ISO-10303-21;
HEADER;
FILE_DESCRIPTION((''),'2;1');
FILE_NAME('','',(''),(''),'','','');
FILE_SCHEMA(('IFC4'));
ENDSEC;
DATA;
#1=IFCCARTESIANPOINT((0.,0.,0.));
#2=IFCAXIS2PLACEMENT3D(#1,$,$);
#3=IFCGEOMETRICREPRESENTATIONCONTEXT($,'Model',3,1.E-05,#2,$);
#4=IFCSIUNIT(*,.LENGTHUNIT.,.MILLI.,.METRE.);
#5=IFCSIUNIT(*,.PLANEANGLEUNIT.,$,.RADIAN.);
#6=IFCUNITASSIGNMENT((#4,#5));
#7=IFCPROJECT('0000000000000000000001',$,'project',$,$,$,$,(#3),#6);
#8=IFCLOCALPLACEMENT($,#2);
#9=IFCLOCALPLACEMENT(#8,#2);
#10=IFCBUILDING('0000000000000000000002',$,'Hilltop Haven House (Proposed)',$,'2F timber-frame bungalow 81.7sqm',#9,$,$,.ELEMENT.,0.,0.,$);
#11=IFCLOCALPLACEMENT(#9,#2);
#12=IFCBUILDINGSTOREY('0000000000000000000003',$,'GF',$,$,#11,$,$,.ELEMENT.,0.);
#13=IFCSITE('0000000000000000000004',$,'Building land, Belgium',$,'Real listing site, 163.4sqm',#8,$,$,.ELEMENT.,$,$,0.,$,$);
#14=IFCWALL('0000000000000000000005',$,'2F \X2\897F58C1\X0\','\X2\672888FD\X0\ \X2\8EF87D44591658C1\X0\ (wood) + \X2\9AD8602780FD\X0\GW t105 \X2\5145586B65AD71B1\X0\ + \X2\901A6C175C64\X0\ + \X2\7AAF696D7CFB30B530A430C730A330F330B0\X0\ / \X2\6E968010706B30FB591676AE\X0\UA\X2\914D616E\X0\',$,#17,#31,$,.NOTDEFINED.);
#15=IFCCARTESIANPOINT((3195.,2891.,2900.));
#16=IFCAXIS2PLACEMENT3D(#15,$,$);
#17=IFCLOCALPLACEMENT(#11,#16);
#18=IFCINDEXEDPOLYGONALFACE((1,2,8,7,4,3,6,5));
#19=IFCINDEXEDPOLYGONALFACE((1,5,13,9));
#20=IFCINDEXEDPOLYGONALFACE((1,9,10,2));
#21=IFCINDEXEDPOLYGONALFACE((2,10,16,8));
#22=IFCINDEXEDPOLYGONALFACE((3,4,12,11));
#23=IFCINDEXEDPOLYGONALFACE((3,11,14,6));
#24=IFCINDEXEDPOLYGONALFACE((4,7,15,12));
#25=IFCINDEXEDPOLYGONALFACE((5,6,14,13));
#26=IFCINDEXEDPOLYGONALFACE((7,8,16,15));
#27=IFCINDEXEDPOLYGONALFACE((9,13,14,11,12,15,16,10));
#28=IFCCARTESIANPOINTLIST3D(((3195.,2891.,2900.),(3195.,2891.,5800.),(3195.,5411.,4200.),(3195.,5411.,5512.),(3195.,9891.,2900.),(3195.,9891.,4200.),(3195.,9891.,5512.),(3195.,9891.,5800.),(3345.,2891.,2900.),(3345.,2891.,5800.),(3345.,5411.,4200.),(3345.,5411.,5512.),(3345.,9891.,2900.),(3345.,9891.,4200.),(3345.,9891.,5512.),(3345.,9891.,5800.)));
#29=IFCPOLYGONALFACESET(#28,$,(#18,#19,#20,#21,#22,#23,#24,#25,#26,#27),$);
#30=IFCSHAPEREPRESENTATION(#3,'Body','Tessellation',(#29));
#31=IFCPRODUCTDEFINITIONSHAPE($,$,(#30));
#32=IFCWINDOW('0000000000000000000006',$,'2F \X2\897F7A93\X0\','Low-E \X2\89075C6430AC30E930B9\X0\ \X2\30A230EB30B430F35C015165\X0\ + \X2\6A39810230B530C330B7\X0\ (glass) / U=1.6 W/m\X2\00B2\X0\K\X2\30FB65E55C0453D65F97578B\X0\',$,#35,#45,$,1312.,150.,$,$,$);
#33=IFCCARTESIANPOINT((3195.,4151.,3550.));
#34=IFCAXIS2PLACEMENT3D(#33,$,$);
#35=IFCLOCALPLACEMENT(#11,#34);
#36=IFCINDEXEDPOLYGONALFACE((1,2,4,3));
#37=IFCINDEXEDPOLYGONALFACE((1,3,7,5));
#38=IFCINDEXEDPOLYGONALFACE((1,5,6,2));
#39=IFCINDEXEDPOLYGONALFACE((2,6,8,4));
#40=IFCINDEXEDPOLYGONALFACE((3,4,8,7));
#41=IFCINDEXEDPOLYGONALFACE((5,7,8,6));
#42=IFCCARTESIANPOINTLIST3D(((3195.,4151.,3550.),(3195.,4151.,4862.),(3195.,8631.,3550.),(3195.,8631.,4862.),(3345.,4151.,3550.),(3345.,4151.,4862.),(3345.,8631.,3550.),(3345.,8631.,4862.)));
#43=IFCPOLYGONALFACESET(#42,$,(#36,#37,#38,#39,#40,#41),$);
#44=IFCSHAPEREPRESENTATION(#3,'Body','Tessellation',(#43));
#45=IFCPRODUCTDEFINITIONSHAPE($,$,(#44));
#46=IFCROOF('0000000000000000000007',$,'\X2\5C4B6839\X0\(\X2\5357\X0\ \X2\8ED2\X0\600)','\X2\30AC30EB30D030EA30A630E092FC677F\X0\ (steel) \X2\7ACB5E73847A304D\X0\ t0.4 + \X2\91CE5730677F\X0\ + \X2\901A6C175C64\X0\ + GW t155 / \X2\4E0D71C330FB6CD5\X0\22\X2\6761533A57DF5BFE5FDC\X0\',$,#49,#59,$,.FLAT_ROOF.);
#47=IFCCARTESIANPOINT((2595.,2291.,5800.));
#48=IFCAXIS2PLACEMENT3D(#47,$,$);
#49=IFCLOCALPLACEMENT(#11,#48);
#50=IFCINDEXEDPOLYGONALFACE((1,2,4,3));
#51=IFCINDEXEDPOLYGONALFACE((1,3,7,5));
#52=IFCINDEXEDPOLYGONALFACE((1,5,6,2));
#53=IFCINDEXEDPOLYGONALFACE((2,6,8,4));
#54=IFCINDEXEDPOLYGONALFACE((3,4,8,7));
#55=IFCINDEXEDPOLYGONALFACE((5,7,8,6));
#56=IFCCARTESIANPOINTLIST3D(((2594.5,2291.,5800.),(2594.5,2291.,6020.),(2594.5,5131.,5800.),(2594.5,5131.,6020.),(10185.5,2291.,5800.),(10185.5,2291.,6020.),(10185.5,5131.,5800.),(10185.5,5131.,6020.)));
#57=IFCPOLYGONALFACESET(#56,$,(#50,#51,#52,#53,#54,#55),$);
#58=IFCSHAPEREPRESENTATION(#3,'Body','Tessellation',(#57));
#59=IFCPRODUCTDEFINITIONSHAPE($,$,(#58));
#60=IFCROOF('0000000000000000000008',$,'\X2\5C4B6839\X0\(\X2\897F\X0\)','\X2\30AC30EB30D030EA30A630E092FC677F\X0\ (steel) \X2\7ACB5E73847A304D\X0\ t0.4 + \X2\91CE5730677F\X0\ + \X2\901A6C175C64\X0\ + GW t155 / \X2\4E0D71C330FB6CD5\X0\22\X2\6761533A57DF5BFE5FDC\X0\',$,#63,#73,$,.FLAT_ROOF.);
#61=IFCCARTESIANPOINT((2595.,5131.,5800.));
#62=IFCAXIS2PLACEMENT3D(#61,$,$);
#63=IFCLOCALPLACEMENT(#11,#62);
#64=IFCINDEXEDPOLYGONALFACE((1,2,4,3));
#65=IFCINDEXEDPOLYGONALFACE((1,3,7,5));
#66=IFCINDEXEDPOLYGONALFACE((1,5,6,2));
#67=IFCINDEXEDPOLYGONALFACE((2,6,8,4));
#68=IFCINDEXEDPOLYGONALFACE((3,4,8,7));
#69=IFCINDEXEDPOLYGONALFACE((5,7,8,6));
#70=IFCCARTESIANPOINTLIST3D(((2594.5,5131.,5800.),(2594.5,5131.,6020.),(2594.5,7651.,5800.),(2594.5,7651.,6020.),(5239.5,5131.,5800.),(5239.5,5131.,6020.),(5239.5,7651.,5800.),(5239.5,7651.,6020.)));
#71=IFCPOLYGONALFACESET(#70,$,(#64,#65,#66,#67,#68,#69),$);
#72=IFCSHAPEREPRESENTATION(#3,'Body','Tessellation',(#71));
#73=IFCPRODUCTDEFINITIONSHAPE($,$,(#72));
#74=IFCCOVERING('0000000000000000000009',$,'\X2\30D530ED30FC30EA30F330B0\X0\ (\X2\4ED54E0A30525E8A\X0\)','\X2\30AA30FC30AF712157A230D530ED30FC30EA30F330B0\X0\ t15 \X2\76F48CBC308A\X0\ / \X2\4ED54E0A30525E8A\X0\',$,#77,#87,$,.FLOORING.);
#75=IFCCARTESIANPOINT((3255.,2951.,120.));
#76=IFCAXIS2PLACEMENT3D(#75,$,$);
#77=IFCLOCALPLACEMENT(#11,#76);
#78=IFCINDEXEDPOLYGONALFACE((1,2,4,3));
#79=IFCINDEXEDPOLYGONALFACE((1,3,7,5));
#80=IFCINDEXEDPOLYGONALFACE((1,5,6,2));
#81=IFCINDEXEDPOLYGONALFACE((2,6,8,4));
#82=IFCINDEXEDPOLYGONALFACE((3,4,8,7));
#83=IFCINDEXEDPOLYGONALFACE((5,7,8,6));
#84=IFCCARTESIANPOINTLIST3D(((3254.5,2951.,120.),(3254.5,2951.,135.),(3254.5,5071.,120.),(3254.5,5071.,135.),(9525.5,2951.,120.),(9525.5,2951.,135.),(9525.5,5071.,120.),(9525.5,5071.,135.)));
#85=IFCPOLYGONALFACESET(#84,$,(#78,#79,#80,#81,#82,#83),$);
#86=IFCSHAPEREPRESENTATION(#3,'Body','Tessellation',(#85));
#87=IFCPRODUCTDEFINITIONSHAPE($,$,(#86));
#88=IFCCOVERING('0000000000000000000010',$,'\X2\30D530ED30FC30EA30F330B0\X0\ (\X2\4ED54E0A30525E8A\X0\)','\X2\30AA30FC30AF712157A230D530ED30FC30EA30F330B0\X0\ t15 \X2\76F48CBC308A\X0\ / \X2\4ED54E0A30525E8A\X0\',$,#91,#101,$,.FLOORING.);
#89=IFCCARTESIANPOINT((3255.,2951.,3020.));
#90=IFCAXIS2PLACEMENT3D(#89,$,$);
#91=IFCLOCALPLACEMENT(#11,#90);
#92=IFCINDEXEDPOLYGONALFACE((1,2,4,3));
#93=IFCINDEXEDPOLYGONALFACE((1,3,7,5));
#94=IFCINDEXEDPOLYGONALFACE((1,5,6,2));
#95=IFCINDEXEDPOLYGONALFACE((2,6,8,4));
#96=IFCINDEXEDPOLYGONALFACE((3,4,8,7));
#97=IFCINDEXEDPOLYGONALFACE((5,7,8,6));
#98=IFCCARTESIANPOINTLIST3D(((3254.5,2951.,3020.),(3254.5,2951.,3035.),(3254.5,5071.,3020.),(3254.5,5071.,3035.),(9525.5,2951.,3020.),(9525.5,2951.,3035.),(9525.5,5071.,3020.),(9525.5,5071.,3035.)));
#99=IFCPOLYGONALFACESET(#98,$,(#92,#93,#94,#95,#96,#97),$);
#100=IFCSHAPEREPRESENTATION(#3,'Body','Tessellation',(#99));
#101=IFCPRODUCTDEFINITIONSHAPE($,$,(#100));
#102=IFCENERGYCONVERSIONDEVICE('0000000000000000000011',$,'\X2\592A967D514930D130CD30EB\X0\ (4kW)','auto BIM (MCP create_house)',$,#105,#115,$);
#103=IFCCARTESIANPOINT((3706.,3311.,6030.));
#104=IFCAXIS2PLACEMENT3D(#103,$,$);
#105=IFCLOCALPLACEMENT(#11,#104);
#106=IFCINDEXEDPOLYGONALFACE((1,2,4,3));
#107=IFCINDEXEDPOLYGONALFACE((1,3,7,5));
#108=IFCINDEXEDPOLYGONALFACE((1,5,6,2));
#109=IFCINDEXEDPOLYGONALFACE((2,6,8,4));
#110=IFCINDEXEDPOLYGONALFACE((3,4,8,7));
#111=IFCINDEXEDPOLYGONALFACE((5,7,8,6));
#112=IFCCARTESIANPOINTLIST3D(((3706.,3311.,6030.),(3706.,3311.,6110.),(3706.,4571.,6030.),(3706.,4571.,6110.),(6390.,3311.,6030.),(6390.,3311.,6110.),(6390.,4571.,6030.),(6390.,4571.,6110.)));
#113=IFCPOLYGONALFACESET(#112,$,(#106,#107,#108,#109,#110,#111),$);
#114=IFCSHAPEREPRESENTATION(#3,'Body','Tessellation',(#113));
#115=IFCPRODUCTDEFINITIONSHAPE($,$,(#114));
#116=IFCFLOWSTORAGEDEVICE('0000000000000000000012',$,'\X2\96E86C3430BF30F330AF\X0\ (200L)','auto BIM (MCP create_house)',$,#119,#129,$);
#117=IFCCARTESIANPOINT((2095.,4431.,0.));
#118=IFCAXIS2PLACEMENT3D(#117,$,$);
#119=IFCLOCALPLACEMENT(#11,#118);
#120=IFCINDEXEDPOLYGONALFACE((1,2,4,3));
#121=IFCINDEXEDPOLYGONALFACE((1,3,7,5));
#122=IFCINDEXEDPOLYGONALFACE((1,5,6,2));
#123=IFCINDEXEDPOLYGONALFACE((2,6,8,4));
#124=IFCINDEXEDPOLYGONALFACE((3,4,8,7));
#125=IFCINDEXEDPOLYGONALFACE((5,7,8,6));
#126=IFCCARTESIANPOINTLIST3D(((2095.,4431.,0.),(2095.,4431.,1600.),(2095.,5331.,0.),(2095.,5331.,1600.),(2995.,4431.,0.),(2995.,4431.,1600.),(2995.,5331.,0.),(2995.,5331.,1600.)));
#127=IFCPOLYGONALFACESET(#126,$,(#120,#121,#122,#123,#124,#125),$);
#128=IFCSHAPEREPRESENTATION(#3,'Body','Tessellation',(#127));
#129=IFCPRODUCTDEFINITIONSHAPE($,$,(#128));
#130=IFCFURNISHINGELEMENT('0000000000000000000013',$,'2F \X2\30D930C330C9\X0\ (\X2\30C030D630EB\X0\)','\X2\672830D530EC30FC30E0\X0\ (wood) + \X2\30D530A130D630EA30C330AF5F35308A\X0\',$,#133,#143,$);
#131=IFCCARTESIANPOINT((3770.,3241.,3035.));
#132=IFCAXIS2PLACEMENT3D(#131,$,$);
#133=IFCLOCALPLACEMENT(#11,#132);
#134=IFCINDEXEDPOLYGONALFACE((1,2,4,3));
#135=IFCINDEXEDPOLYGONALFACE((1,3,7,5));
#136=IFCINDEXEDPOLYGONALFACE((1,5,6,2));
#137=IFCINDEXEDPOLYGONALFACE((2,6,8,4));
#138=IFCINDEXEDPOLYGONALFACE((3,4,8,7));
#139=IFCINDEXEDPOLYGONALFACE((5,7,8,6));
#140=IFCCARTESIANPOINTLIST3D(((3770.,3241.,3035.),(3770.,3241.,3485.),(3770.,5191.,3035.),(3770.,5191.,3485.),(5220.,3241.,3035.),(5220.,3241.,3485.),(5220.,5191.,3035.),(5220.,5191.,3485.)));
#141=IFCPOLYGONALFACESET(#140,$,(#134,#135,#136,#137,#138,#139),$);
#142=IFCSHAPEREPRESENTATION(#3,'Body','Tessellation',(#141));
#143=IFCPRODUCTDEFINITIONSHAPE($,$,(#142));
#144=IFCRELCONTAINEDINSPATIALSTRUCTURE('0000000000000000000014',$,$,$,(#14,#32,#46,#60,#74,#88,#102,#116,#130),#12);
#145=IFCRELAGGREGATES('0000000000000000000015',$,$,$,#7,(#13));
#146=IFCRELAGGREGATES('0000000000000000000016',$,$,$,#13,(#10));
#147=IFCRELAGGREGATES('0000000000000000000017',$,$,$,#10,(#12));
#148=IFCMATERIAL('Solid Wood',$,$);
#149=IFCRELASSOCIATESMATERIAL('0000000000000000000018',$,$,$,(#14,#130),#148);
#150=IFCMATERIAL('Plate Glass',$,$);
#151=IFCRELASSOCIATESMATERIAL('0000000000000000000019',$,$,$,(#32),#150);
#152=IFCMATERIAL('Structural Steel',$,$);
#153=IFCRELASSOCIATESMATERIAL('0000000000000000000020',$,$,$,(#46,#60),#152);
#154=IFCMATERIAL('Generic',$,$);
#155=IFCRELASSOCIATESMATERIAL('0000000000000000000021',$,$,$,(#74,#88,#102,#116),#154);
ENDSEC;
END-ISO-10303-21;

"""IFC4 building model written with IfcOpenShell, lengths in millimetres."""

from ifc_helpers import new_model, si_unit, frame, frame_2d, origin, place, context, project, spatial, rectangle, extrude, material, element, fill, save


model = new_model("IFC4")

# Units and contexts
model_context = context("Model", 3, precision=1e-05, world=origin())
ifc_project = project(units=[si_unit("LENGTHUNIT", "METRE", prefix="MILLI"), si_unit("PLANEANGLEUNIT", "RADIAN")], contexts=[model_context])

# Site, building, storey
site_placement = place(None, origin())
site = spatial("IfcSite", under=ifc_project, at=site_placement, Name="Building land, Belgium", ObjectType="Real listing site, 163.4sqm", CompositionType="ELEMENT", RefElevation=0.0)
building_placement = place(site_placement, origin())
building = spatial("IfcBuilding", under=site, at=building_placement, Name="Hilltop Haven House (Proposed)", ObjectType="2F timber-frame bungalow 81.7sqm", CompositionType="ELEMENT", ElevationOfRefHeight=0.0, ElevationOfTerrain=0.0)
storey_placement = place(building_placement, origin())
storey = spatial("IfcBuildingStorey", under=building, at=storey_placement, Name="GF", CompositionType="ELEMENT", Elevation=0.0)

# Shared definitions
ifc_material_1 = material(Name="Solid Wood")

# Shared definitions
ifc_material_2 = material(Name="Plate Glass")

# Wall, opening, window
wall_1_placement = place(storey_placement, frame((3195.0, 2891.0, 2900.0)))
wall_1 = element("IfcWall", 1, at=wall_1_placement, inside=storey, material=ifc_material_1, Name="2F 西壁", Description="木製 軸組外壁 (wood) + 高性能GW t105 充填断熱 + 通気層 + 窯業系サイディング / 準耐火・外皮UA配慮", PredefinedType="NOTDEFINED", context=model_context, shape_type="SweptSolid", body=[
    extrude(rectangle(XDim=150.0, YDim=7000.0, at=frame_2d((75.0, 3500.0))), frame((3195.0, 2891.0, 2900.0)), (0.0, 0.0, 1.0), 2900.0),
])
opening_1_placement = place(storey_placement, frame((3195.0, 4151.0, 3550.0)))
opening_1 = element("IfcOpeningElement", 2, at=opening_1_placement, cuts=wall_1, PredefinedType="NOTDEFINED", context=model_context, shape_type="SweptSolid", body=[
    extrude(rectangle(XDim=150.0, YDim=4480.0, at=frame_2d((75.0, 2240.0))), frame((3195.0, 4151.0, 3550.0)), (0.0, 0.0, 1.0), 1312.0),
])
window_1_placement = place(storey_placement, frame((3195.0, 4151.0, 3550.0)))
window_1 = element("IfcWindow", 3, at=window_1_placement, inside=storey, material=ifc_material_2, Name="2F 西窓", Description="Low-E 複層ガラス アルゴン封入 + 樹脂サッシ (glass) / U=1.6 W/m²K・日射取得型", OverallHeight=1312.0, OverallWidth=150.0, context=model_context, shape_type="SweptSolid", body=[
    extrude(rectangle(XDim=150.0, YDim=4480.0, at=frame_2d((75.0, 2240.0))), frame((3195.0, 4151.0, 3550.0)), (0.0, 0.0, 1.0), 1312.0),
])
fill(opening_1, window_1)

# Roofs
ifc_material_3 = material(Name="Structural Steel")
roof_1_placement = place(storey_placement, frame((2595.0, 2291.0, 5800.0)))
element("IfcRoof", 4, at=roof_1_placement, inside=storey, material=ifc_material_3, Name="屋根(南 軒600)", Description="ガルバリウム鋼板 (steel) 立平葺き t0.4 + 野地板 + 通気層 + GW t155 / 不燃・法22条区域対応", PredefinedType="FLAT_ROOF", context=model_context, shape_type="SweptSolid", body=[
    extrude(rectangle(XDim=7591.0, YDim=2840.0, at=frame_2d((3795.0, 1420.0))), frame((2595.0, 2291.0, 5800.0)), (0.0, 0.0, 1.0), 220.0),
])
roof_2_placement = place(storey_placement, frame((2595.0, 5131.0, 5800.0)))
element("IfcRoof", 5, at=roof_2_placement, inside=storey, material=ifc_material_3, Name="屋根(西)", Description="ガルバリウム鋼板 (steel) 立平葺き t0.4 + 野地板 + 通気層 + GW t155 / 不燃・法22条区域対応", PredefinedType="FLAT_ROOF", context=model_context, shape_type="SweptSolid", body=[
    extrude(rectangle(XDim=2645.0, YDim=2520.0, at=frame_2d((1322.0, 1260.0))), frame((2595.0, 5131.0, 5800.0)), (0.0, 0.0, 1.0), 220.0),
])

# Coverings
ifc_material_4 = material(Name="Generic")
covering_1_placement = place(storey_placement, frame((3255.0, 2951.0, 120.0)))
element("IfcCovering", 6, at=covering_1_placement, inside=storey, material=ifc_material_4, Name="フローリング (仕上げ床)", Description="オーク無垢フローリング t15 直貼り / 仕上げ床", PredefinedType="FLOORING", context=model_context, shape_type="SweptSolid", body=[
    extrude(rectangle(XDim=6271.0, YDim=2120.0, at=frame_2d((3135.0, 1060.0))), frame((3255.0, 2951.0, 120.0)), (0.0, 0.0, 1.0), 15.0),
])
covering_2_placement = place(storey_placement, frame((3255.0, 2951.0, 3020.0)))
element("IfcCovering", 7, at=covering_2_placement, inside=storey, material=ifc_material_4, Name="フローリング (仕上げ床)", Description="オーク無垢フローリング t15 直貼り / 仕上げ床", PredefinedType="FLOORING", context=model_context, shape_type="SweptSolid", body=[
    extrude(rectangle(XDim=6271.0, YDim=2120.0, at=frame_2d((3135.0, 1060.0))), frame((3255.0, 2951.0, 3020.0)), (0.0, 0.0, 1.0), 15.0),
])

# Energy conversion device
energy_conversion_device_placement = place(storey_placement, frame((3706.0, 3311.0, 6030.0)))
element("IfcEnergyConversionDevice", 8, at=energy_conversion_device_placement, inside=storey, material=ifc_material_4, Name="太陽光パネル (4kW)", Description="auto BIM (MCP create_house)", context=model_context, shape_type="SweptSolid", body=[
    extrude(rectangle(XDim=2684.0, YDim=1260.0, at=frame_2d((1342.0, 630.0))), frame((3706.0, 3311.0, 6030.0)), (0.0, 0.0, 1.0), 80.0),
])

# Flow storage device
flow_storage_device_placement = place(storey_placement, frame((2095.0, 4431.0, 0.0)))
element("IfcFlowStorageDevice", 9, at=flow_storage_device_placement, inside=storey, material=ifc_material_4, Name="雨水タンク (200L)", Description="auto BIM (MCP create_house)", context=model_context, shape_type="SweptSolid", body=[
    extrude(rectangle(XDim=900.0, YDim=900.0, at=frame_2d((450.0, 450.0))), frame((2095.0, 4431.0, 0.0)), (0.0, 0.0, 1.0), 1600.0),
])

# Furnishing element
furnishing_placement = place(storey_placement, frame((3770.0, 3241.0, 3035.0)))
element("IfcFurnishingElement", 10, at=furnishing_placement, inside=storey, material=ifc_material_1, Name="2F ベッド (ダブル)", Description="木フレーム (wood) + ファブリック張り", context=model_context, shape_type="SweptSolid", body=[
    extrude(rectangle(XDim=1450.0, YDim=1950.0, at=frame_2d((725.0, 975.0))), frame((3770.0, 3241.0, 3035.0)), (0.0, 0.0, 1.0), 450.0),
])

save(model, "model.ifc")
